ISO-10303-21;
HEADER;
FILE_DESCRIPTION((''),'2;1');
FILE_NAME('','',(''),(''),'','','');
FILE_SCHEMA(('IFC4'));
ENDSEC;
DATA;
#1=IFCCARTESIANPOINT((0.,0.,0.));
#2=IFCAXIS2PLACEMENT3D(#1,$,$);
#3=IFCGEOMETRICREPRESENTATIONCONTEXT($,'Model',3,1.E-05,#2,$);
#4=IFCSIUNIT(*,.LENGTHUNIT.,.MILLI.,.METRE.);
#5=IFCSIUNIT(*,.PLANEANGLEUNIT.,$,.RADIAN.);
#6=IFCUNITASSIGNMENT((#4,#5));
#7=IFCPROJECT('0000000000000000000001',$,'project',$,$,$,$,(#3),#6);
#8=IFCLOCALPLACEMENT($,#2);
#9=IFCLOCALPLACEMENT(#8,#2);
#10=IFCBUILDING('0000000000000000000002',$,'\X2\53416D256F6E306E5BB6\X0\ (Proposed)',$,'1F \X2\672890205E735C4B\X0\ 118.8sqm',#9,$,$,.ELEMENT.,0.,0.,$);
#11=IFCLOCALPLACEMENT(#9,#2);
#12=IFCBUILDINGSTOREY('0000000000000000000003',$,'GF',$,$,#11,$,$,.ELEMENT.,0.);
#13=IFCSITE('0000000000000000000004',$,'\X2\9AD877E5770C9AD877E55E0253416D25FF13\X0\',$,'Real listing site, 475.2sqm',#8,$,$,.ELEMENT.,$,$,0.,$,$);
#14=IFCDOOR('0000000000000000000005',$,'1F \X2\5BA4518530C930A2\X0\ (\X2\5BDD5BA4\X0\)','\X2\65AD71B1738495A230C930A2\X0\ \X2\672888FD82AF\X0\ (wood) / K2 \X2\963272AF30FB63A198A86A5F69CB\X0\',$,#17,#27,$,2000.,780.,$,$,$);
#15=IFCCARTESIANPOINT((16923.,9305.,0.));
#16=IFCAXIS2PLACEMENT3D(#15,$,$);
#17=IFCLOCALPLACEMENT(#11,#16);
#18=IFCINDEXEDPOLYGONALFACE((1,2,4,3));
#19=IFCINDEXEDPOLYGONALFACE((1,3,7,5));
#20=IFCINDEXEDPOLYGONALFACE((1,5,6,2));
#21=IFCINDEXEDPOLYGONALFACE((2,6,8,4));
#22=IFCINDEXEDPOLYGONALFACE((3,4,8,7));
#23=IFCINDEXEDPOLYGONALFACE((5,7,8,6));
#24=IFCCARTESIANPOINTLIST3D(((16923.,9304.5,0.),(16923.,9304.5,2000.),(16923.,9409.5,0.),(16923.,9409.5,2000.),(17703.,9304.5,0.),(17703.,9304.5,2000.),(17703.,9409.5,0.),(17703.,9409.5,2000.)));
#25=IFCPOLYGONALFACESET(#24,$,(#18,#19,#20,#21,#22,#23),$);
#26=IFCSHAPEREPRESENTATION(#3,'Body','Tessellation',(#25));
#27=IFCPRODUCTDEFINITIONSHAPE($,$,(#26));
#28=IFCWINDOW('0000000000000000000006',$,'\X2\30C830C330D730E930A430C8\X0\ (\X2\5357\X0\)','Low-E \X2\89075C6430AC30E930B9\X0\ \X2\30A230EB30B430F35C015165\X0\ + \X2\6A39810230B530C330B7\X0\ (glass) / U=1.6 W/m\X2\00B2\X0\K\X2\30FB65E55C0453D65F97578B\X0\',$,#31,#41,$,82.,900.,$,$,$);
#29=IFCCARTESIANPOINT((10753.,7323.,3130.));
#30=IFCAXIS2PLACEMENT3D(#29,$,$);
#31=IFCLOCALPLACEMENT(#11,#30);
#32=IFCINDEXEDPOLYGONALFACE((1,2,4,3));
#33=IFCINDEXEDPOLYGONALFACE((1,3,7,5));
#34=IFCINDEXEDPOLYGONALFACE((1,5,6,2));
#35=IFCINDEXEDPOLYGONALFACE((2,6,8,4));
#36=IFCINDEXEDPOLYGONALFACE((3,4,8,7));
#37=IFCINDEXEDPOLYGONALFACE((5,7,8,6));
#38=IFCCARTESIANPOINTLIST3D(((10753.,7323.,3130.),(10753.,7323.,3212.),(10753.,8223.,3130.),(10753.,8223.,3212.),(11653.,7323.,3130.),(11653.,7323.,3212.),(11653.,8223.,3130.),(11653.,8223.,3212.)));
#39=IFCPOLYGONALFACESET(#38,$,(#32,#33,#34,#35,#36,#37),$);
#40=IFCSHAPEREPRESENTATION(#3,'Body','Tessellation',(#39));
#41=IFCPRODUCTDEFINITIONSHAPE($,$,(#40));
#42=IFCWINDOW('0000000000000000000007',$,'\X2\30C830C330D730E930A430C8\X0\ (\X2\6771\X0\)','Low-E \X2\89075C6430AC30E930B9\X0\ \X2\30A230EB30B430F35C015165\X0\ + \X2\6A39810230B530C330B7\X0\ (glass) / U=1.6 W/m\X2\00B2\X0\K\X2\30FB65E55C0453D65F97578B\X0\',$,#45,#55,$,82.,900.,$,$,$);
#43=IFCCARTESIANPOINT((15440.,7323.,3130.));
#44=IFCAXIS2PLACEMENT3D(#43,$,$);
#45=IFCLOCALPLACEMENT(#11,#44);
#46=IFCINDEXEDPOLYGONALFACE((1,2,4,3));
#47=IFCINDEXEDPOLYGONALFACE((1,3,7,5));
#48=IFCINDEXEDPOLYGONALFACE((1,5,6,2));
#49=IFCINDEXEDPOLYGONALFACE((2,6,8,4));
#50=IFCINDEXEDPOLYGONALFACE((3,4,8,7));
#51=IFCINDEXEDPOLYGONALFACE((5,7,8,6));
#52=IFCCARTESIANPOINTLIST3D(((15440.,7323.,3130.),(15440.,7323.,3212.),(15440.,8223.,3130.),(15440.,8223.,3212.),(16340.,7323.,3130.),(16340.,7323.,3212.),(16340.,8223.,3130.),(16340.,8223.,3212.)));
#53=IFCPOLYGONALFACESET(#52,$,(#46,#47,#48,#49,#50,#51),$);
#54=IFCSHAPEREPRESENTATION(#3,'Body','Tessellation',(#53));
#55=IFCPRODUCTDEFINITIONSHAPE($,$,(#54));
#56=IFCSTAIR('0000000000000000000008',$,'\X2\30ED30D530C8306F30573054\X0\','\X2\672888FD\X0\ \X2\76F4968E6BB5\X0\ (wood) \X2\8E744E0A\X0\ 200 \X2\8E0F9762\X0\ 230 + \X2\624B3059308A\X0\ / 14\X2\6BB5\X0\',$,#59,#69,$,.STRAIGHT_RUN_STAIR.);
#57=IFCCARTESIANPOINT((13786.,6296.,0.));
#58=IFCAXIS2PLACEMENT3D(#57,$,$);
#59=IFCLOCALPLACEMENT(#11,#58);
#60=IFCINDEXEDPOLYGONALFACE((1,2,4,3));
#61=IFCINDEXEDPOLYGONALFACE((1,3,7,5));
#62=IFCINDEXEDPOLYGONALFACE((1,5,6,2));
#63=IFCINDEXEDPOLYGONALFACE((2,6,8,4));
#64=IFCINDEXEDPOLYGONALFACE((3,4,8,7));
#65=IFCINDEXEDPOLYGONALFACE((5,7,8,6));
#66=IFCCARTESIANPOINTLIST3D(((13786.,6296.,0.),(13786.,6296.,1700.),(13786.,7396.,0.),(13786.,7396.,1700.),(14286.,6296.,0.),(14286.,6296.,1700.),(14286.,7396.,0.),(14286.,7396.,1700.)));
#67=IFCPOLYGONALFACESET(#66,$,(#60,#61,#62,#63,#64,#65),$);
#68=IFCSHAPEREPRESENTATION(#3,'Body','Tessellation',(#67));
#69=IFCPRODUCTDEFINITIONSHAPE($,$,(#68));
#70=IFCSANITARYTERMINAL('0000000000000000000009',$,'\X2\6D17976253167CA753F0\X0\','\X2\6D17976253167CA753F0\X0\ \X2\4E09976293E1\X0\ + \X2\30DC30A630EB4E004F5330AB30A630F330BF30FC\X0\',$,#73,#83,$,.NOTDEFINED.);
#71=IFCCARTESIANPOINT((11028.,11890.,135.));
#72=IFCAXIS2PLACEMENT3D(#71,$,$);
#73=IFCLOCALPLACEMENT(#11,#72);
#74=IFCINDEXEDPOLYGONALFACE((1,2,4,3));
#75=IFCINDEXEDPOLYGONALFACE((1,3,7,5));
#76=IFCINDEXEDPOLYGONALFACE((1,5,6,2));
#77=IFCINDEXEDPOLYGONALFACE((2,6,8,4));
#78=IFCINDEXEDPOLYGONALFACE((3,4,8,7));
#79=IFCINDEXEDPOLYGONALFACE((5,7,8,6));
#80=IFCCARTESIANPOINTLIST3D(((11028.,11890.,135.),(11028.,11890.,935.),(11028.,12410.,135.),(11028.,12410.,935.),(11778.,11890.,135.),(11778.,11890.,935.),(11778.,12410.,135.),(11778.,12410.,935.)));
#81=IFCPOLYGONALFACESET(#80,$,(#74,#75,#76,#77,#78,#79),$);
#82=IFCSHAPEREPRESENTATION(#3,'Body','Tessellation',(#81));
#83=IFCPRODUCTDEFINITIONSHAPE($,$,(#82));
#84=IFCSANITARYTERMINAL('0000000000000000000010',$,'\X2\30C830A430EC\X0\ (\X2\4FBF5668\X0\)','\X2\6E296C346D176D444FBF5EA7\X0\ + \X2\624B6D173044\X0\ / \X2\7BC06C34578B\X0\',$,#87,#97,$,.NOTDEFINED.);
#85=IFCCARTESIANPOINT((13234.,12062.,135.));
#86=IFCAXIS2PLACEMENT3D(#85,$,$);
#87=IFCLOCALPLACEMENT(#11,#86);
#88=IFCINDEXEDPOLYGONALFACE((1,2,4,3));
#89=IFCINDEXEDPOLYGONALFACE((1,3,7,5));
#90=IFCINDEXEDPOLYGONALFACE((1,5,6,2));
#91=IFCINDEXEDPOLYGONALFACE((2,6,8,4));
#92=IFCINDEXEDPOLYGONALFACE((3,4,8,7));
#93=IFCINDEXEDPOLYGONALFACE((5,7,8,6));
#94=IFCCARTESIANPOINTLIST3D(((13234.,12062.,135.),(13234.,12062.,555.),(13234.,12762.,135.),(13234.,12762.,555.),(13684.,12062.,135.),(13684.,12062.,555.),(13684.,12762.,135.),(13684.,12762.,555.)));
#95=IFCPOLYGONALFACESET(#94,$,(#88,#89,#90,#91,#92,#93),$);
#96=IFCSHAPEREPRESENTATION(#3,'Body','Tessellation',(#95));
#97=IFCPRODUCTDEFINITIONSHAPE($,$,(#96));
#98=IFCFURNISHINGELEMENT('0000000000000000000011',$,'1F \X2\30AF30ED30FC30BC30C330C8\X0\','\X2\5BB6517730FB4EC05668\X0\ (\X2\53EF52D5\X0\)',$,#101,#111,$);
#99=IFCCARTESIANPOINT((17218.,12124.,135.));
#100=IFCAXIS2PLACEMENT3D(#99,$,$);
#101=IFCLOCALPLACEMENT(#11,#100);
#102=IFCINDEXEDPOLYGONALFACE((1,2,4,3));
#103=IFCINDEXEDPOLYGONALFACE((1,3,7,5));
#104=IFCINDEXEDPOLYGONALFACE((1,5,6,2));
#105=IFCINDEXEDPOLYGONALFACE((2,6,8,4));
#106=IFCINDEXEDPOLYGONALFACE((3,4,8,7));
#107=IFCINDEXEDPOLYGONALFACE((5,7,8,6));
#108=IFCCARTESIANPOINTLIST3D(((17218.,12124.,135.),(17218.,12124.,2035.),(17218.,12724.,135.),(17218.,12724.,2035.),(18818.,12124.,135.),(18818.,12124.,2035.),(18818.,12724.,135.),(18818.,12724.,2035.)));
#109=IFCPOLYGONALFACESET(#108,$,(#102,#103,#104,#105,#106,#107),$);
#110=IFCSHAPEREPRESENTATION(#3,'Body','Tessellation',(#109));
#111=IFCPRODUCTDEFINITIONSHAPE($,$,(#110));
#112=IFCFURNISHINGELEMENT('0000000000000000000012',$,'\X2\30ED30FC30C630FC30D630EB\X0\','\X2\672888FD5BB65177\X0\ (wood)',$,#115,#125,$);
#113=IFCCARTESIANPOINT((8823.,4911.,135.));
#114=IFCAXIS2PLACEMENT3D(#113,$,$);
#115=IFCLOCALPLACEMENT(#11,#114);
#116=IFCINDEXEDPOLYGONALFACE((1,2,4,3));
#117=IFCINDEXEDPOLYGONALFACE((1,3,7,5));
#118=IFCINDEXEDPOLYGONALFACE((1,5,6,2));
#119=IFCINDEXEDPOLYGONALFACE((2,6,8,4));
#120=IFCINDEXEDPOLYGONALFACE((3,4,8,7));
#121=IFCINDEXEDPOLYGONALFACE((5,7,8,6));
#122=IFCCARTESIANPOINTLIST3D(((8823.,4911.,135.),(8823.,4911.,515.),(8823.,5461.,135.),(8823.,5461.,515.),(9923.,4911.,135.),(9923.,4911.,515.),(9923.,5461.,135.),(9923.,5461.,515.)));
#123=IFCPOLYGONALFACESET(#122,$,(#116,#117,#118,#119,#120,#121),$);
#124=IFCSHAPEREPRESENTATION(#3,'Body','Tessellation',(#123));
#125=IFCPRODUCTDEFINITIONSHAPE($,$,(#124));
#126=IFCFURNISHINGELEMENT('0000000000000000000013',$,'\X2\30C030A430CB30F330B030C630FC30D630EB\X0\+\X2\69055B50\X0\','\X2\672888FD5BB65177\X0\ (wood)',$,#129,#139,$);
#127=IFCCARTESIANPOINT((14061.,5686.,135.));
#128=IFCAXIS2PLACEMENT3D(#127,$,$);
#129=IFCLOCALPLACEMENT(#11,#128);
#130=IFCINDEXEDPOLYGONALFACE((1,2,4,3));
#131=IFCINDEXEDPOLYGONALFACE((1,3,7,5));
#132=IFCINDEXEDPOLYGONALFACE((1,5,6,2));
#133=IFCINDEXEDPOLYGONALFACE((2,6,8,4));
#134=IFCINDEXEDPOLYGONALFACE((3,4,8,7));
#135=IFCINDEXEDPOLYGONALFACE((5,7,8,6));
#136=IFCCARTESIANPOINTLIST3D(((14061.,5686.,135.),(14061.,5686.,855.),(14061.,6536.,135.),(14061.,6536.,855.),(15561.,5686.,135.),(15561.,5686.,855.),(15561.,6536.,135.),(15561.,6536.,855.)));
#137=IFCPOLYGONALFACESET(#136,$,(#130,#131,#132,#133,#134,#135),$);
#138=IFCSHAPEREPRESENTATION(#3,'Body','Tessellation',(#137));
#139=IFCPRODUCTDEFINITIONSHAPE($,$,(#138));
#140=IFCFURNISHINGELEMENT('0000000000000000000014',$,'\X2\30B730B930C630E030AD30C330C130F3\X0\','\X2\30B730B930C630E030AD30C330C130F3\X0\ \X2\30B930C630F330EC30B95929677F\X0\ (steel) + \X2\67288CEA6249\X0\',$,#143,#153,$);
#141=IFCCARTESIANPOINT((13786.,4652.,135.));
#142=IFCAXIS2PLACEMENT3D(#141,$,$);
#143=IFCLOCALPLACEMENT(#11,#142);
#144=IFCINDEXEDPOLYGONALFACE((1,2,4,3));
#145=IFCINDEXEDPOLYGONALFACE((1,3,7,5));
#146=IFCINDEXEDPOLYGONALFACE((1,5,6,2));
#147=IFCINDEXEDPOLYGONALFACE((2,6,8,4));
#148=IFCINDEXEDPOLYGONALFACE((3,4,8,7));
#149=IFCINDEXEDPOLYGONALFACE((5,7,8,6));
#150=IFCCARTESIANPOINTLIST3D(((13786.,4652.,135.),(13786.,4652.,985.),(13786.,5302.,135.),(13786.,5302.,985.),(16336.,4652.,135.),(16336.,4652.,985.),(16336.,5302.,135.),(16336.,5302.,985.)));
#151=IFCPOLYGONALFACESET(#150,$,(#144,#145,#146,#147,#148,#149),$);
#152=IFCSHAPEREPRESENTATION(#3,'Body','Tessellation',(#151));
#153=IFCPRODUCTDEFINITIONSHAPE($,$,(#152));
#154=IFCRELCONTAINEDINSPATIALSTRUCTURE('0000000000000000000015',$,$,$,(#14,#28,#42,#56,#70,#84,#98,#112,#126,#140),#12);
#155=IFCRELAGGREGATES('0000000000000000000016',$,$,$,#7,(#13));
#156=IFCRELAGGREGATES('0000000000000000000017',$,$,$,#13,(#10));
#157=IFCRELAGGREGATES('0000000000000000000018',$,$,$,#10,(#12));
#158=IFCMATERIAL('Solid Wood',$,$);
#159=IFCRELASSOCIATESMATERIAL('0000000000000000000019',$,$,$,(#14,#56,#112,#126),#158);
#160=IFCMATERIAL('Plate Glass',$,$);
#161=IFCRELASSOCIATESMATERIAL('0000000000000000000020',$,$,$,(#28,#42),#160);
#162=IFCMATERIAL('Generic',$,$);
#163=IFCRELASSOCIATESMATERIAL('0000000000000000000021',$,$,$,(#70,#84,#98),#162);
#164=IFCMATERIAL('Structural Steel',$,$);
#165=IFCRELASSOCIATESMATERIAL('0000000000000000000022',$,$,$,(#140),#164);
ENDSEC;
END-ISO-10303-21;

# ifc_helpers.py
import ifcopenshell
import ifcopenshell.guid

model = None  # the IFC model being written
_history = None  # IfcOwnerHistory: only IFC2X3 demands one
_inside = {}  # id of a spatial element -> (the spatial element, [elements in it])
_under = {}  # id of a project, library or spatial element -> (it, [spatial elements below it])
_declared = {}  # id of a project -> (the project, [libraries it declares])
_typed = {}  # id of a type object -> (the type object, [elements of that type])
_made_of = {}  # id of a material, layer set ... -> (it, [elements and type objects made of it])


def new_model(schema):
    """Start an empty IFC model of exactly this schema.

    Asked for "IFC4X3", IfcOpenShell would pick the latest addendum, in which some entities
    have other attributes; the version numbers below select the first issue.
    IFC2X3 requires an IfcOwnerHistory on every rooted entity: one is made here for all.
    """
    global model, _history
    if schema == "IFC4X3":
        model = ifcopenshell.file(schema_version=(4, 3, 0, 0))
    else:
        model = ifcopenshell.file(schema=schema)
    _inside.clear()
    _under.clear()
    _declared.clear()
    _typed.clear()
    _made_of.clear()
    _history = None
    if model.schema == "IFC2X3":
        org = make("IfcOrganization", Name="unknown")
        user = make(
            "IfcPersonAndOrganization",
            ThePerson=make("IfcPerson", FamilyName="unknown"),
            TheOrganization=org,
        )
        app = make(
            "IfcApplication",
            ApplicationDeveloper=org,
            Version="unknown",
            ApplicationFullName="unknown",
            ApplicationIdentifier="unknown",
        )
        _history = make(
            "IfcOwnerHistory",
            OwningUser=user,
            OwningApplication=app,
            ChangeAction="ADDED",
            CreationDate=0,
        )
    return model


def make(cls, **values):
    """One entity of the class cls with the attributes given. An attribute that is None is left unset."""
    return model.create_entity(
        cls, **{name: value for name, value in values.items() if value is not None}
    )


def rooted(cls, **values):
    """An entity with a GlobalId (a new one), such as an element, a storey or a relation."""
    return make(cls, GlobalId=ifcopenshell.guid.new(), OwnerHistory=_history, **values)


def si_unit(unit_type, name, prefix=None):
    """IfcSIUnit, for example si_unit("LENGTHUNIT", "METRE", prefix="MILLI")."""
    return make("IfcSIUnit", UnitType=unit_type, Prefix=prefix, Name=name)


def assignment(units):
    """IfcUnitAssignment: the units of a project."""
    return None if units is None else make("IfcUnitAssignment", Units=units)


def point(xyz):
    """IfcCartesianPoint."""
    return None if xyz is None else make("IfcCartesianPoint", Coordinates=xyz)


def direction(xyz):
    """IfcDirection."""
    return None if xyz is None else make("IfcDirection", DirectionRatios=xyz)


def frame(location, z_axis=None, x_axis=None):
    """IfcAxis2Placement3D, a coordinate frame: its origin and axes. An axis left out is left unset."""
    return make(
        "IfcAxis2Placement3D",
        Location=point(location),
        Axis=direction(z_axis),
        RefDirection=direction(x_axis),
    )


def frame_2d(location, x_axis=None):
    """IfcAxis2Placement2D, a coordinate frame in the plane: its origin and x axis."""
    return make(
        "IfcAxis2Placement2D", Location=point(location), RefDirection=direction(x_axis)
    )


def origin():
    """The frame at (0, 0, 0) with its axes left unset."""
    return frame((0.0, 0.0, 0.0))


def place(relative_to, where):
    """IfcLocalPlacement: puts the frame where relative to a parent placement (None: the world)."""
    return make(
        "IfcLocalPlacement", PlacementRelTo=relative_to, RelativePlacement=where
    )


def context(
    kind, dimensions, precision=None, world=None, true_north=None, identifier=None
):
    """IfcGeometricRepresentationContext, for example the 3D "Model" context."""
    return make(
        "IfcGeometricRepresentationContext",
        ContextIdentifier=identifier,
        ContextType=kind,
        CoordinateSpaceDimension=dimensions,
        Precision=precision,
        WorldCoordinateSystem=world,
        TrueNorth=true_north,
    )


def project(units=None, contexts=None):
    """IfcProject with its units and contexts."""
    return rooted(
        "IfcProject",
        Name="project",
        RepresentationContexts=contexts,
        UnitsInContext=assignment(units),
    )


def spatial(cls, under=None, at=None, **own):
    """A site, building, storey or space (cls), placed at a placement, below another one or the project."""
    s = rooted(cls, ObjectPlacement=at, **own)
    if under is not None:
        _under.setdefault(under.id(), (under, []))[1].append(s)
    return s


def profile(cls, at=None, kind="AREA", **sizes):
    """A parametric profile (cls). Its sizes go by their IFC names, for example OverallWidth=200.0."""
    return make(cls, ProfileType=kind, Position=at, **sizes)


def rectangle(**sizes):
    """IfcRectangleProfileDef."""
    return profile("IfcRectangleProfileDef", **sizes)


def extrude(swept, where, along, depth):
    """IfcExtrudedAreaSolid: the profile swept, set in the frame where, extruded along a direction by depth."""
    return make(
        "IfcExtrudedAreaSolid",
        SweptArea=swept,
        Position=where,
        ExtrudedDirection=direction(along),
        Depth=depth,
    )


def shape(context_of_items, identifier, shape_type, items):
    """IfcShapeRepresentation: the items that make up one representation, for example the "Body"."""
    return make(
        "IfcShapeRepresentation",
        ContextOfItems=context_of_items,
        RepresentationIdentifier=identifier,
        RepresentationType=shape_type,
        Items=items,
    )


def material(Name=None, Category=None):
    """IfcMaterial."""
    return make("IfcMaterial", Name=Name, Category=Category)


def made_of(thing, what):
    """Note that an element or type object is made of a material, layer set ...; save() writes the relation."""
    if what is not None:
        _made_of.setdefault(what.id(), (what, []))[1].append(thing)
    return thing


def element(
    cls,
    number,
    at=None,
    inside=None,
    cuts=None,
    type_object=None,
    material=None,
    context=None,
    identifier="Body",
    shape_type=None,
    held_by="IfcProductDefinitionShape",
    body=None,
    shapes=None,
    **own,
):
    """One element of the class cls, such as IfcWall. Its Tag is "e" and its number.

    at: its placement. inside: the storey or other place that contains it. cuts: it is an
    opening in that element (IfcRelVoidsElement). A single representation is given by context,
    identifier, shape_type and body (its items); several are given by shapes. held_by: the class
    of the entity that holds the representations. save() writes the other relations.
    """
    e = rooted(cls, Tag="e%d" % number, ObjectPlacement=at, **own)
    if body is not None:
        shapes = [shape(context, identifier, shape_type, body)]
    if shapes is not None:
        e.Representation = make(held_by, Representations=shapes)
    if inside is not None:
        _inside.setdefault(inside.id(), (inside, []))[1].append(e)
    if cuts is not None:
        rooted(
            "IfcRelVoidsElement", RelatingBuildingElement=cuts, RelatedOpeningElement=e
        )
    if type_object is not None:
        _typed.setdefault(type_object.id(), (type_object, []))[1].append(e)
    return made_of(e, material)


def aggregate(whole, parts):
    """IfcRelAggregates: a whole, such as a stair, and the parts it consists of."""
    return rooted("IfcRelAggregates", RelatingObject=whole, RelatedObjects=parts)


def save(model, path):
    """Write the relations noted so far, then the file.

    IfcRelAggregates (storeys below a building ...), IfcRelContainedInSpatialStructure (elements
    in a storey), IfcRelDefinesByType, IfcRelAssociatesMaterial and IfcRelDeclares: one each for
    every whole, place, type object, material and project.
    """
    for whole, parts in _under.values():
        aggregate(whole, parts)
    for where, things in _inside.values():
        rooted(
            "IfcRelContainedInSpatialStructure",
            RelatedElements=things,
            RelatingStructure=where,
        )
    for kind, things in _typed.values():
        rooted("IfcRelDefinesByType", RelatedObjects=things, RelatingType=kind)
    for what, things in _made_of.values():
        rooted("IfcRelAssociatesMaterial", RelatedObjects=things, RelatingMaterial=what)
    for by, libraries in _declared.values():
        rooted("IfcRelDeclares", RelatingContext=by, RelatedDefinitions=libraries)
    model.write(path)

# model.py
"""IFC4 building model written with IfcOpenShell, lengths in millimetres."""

from ifc_helpers import new_model, si_unit, frame, frame_2d, origin, place, context, project, spatial, rectangle, extrude, material, element, save


model = new_model("IFC4")

# Units and contexts
model_context = context("Model", 3, precision=1e-05, world=origin())
ifc_project = project(units=[si_unit("LENGTHUNIT", "METRE", prefix="MILLI"), si_unit("PLANEANGLEUNIT", "RADIAN")], contexts=[model_context])

# Site, building, storey
site_placement = place(None, origin())
site = spatial("IfcSite", under=ifc_project, at=site_placement, Name="高知県高知市十津３", ObjectType="Real listing site, 475.2sqm", CompositionType="ELEMENT", RefElevation=0.0)
building_placement = place(site_placement, origin())
building = spatial("IfcBuilding", under=site, at=building_placement, Name="十津潮の家 (Proposed)", ObjectType="1F 木造平屋 118.8sqm", CompositionType="ELEMENT", ElevationOfRefHeight=0.0, ElevationOfTerrain=0.0)
storey_placement = place(building_placement, origin())
storey = spatial("IfcBuildingStorey", under=building, at=storey_placement, Name="GF", CompositionType="ELEMENT", Elevation=0.0)

# Shared definitions
ifc_material_1 = material(Name="Solid Wood")
ifc_material_2 = material(Name="Plate Glass")

# Door
door_placement = place(storey_placement, frame((16923.0, 9305.0, 0.0)))
element("IfcDoor", 1, at=door_placement, inside=storey, material=ifc_material_1, Name="1F 室内ドア (寝室)", Description="断熱玄関ドア 木製芯 (wood) / K2 防犯・採風機構", OverallHeight=2000.0, OverallWidth=780.0, context=model_context, shape_type="SweptSolid", body=[
    extrude(rectangle(XDim=780.0, YDim=105.0, at=frame_2d((390.0, 52.0))), frame((16923.0, 9305.0, 0.0)), (0.0, 0.0, 1.0), 2000.0),
])

# Windows
window_1_placement = place(storey_placement, frame((10753.0, 7323.0, 3130.0)))
element("IfcWindow", 2, at=window_1_placement, inside=storey, material=ifc_material_2, Name="トップライト (南)", Description="Low-E 複層ガラス アルゴン封入 + 樹脂サッシ (glass) / U=1.6 W/m²K・日射取得型", OverallHeight=82.0, OverallWidth=900.0, context=model_context, shape_type="SweptSolid", body=[
    extrude(rectangle(XDim=900.0, YDim=900.0, at=frame_2d((450.0, 450.0))), frame((10753.0, 7323.0, 3130.0)), (0.0, 0.0, 1.0), 82.0),
])
window_2_placement = place(storey_placement, frame((15440.0, 7323.0, 3130.0)))
element("IfcWindow", 3, at=window_2_placement, inside=storey, material=ifc_material_2, Name="トップライト (東)", Description="Low-E 複層ガラス アルゴン封入 + 樹脂サッシ (glass) / U=1.6 W/m²K・日射取得型", OverallHeight=82.0, OverallWidth=900.0, context=model_context, shape_type="SweptSolid", body=[
    extrude(rectangle(XDim=900.0, YDim=900.0, at=frame_2d((450.0, 450.0))), frame((15440.0, 7323.0, 3130.0)), (0.0, 0.0, 1.0), 82.0),
])

# Stair
stair_placement = place(storey_placement, frame((13786.0, 6296.0, 0.0)))
element("IfcStair", 4, at=stair_placement, inside=storey, material=ifc_material_1, Name="ロフトはしご", Description="木製 直階段 (wood) 蹴上 200 踏面 230 + 手すり / 14段", PredefinedType="STRAIGHT_RUN_STAIR", context=model_context, shape_type="SweptSolid", body=[
    extrude(rectangle(XDim=500.0, YDim=1100.0, at=frame_2d((250.0, 550.0))), frame((13786.0, 6296.0, 0.0)), (0.0, 0.0, 1.0), 1700.0),
])

# Sanitary terminals
ifc_material_3 = material(Name="Generic")
sanitary_terminal_1_placement = place(storey_placement, frame((11028.0, 11890.0, 135.0)))
element("IfcSanitaryTerminal", 5, at=sanitary_terminal_1_placement, inside=storey, material=ifc_material_3, Name="洗面化粧台", Description="洗面化粧台 三面鏡 + ボウル一体カウンター", PredefinedType="NOTDEFINED", context=model_context, shape_type="SweptSolid", body=[
    extrude(rectangle(XDim=750.0, YDim=520.0, at=frame_2d((375.0, 260.0))), frame((11028.0, 11890.0, 135.0)), (0.0, 0.0, 1.0), 800.0),
])
sanitary_terminal_2_placement = place(storey_placement, frame((13234.0, 12062.0, 135.0)))
element("IfcSanitaryTerminal", 6, at=sanitary_terminal_2_placement, inside=storey, material=ifc_material_3, Name="トイレ (便器)", Description="温水洗浄便座 + 手洗い / 節水型", PredefinedType="NOTDEFINED", context=model_context, shape_type="SweptSolid", body=[
    extrude(rectangle(XDim=450.0, YDim=700.0, at=frame_2d((225.0, 350.0))), frame((13234.0, 12062.0, 135.0)), (0.0, 0.0, 1.0), 420.0),
])

# Furnishing elements
furnishing_1_placement = place(storey_placement, frame((17218.0, 12124.0, 135.0)))
element("IfcFurnishingElement", 7, at=furnishing_1_placement, inside=storey, material=ifc_material_3, Name="1F クローゼット", Description="家具・什器 (可動)", context=model_context, shape_type="SweptSolid", body=[
    extrude(rectangle(XDim=1600.0, YDim=600.0, at=frame_2d((800.0, 300.0))), frame((17218.0, 12124.0, 135.0)), (0.0, 0.0, 1.0), 1900.0),
])
furnishing_2_placement = place(storey_placement, frame((8823.0, 4911.0, 135.0)))
element("IfcFurnishingElement", 8, at=furnishing_2_placement, inside=storey, material=ifc_material_1, Name="ローテーブル", Description="木製家具 (wood)", context=model_context, shape_type="SweptSolid", body=[
    extrude(rectangle(XDim=1100.0, YDim=550.0, at=frame_2d((550.0, 275.0))), frame((8823.0, 4911.0, 135.0)), (0.0, 0.0, 1.0), 380.0),
])
furnishing_3_placement = place(storey_placement, frame((14061.0, 5686.0, 135.0)))
element("IfcFurnishingElement", 9, at=furnishing_3_placement, inside=storey, material=ifc_material_1, Name="ダイニングテーブル+椅子", Description="木製家具 (wood)", context=model_context, shape_type="SweptSolid", body=[
    extrude(rectangle(XDim=1500.0, YDim=850.0, at=frame_2d((750.0, 425.0))), frame((14061.0, 5686.0, 135.0)), (0.0, 0.0, 1.0), 720.0),
])
ifc_material_4 = material(Name="Structural Steel")
furnishing_4_placement = place(storey_placement, frame((13786.0, 4652.0, 135.0)))
element("IfcFurnishingElement", 10, at=furnishing_4_placement, inside=storey, material=ifc_material_4, Name="システムキッチン", Description="システムキッチン ステンレス天板 (steel) + 木質扉", context=model_context, shape_type="SweptSolid", body=[
    extrude(rectangle(XDim=2550.0, YDim=650.0, at=frame_2d((1275.0, 325.0))), frame((13786.0, 4652.0, 135.0)), (0.0, 0.0, 1.0), 850.0),
])

save(model, "model.ifc")
